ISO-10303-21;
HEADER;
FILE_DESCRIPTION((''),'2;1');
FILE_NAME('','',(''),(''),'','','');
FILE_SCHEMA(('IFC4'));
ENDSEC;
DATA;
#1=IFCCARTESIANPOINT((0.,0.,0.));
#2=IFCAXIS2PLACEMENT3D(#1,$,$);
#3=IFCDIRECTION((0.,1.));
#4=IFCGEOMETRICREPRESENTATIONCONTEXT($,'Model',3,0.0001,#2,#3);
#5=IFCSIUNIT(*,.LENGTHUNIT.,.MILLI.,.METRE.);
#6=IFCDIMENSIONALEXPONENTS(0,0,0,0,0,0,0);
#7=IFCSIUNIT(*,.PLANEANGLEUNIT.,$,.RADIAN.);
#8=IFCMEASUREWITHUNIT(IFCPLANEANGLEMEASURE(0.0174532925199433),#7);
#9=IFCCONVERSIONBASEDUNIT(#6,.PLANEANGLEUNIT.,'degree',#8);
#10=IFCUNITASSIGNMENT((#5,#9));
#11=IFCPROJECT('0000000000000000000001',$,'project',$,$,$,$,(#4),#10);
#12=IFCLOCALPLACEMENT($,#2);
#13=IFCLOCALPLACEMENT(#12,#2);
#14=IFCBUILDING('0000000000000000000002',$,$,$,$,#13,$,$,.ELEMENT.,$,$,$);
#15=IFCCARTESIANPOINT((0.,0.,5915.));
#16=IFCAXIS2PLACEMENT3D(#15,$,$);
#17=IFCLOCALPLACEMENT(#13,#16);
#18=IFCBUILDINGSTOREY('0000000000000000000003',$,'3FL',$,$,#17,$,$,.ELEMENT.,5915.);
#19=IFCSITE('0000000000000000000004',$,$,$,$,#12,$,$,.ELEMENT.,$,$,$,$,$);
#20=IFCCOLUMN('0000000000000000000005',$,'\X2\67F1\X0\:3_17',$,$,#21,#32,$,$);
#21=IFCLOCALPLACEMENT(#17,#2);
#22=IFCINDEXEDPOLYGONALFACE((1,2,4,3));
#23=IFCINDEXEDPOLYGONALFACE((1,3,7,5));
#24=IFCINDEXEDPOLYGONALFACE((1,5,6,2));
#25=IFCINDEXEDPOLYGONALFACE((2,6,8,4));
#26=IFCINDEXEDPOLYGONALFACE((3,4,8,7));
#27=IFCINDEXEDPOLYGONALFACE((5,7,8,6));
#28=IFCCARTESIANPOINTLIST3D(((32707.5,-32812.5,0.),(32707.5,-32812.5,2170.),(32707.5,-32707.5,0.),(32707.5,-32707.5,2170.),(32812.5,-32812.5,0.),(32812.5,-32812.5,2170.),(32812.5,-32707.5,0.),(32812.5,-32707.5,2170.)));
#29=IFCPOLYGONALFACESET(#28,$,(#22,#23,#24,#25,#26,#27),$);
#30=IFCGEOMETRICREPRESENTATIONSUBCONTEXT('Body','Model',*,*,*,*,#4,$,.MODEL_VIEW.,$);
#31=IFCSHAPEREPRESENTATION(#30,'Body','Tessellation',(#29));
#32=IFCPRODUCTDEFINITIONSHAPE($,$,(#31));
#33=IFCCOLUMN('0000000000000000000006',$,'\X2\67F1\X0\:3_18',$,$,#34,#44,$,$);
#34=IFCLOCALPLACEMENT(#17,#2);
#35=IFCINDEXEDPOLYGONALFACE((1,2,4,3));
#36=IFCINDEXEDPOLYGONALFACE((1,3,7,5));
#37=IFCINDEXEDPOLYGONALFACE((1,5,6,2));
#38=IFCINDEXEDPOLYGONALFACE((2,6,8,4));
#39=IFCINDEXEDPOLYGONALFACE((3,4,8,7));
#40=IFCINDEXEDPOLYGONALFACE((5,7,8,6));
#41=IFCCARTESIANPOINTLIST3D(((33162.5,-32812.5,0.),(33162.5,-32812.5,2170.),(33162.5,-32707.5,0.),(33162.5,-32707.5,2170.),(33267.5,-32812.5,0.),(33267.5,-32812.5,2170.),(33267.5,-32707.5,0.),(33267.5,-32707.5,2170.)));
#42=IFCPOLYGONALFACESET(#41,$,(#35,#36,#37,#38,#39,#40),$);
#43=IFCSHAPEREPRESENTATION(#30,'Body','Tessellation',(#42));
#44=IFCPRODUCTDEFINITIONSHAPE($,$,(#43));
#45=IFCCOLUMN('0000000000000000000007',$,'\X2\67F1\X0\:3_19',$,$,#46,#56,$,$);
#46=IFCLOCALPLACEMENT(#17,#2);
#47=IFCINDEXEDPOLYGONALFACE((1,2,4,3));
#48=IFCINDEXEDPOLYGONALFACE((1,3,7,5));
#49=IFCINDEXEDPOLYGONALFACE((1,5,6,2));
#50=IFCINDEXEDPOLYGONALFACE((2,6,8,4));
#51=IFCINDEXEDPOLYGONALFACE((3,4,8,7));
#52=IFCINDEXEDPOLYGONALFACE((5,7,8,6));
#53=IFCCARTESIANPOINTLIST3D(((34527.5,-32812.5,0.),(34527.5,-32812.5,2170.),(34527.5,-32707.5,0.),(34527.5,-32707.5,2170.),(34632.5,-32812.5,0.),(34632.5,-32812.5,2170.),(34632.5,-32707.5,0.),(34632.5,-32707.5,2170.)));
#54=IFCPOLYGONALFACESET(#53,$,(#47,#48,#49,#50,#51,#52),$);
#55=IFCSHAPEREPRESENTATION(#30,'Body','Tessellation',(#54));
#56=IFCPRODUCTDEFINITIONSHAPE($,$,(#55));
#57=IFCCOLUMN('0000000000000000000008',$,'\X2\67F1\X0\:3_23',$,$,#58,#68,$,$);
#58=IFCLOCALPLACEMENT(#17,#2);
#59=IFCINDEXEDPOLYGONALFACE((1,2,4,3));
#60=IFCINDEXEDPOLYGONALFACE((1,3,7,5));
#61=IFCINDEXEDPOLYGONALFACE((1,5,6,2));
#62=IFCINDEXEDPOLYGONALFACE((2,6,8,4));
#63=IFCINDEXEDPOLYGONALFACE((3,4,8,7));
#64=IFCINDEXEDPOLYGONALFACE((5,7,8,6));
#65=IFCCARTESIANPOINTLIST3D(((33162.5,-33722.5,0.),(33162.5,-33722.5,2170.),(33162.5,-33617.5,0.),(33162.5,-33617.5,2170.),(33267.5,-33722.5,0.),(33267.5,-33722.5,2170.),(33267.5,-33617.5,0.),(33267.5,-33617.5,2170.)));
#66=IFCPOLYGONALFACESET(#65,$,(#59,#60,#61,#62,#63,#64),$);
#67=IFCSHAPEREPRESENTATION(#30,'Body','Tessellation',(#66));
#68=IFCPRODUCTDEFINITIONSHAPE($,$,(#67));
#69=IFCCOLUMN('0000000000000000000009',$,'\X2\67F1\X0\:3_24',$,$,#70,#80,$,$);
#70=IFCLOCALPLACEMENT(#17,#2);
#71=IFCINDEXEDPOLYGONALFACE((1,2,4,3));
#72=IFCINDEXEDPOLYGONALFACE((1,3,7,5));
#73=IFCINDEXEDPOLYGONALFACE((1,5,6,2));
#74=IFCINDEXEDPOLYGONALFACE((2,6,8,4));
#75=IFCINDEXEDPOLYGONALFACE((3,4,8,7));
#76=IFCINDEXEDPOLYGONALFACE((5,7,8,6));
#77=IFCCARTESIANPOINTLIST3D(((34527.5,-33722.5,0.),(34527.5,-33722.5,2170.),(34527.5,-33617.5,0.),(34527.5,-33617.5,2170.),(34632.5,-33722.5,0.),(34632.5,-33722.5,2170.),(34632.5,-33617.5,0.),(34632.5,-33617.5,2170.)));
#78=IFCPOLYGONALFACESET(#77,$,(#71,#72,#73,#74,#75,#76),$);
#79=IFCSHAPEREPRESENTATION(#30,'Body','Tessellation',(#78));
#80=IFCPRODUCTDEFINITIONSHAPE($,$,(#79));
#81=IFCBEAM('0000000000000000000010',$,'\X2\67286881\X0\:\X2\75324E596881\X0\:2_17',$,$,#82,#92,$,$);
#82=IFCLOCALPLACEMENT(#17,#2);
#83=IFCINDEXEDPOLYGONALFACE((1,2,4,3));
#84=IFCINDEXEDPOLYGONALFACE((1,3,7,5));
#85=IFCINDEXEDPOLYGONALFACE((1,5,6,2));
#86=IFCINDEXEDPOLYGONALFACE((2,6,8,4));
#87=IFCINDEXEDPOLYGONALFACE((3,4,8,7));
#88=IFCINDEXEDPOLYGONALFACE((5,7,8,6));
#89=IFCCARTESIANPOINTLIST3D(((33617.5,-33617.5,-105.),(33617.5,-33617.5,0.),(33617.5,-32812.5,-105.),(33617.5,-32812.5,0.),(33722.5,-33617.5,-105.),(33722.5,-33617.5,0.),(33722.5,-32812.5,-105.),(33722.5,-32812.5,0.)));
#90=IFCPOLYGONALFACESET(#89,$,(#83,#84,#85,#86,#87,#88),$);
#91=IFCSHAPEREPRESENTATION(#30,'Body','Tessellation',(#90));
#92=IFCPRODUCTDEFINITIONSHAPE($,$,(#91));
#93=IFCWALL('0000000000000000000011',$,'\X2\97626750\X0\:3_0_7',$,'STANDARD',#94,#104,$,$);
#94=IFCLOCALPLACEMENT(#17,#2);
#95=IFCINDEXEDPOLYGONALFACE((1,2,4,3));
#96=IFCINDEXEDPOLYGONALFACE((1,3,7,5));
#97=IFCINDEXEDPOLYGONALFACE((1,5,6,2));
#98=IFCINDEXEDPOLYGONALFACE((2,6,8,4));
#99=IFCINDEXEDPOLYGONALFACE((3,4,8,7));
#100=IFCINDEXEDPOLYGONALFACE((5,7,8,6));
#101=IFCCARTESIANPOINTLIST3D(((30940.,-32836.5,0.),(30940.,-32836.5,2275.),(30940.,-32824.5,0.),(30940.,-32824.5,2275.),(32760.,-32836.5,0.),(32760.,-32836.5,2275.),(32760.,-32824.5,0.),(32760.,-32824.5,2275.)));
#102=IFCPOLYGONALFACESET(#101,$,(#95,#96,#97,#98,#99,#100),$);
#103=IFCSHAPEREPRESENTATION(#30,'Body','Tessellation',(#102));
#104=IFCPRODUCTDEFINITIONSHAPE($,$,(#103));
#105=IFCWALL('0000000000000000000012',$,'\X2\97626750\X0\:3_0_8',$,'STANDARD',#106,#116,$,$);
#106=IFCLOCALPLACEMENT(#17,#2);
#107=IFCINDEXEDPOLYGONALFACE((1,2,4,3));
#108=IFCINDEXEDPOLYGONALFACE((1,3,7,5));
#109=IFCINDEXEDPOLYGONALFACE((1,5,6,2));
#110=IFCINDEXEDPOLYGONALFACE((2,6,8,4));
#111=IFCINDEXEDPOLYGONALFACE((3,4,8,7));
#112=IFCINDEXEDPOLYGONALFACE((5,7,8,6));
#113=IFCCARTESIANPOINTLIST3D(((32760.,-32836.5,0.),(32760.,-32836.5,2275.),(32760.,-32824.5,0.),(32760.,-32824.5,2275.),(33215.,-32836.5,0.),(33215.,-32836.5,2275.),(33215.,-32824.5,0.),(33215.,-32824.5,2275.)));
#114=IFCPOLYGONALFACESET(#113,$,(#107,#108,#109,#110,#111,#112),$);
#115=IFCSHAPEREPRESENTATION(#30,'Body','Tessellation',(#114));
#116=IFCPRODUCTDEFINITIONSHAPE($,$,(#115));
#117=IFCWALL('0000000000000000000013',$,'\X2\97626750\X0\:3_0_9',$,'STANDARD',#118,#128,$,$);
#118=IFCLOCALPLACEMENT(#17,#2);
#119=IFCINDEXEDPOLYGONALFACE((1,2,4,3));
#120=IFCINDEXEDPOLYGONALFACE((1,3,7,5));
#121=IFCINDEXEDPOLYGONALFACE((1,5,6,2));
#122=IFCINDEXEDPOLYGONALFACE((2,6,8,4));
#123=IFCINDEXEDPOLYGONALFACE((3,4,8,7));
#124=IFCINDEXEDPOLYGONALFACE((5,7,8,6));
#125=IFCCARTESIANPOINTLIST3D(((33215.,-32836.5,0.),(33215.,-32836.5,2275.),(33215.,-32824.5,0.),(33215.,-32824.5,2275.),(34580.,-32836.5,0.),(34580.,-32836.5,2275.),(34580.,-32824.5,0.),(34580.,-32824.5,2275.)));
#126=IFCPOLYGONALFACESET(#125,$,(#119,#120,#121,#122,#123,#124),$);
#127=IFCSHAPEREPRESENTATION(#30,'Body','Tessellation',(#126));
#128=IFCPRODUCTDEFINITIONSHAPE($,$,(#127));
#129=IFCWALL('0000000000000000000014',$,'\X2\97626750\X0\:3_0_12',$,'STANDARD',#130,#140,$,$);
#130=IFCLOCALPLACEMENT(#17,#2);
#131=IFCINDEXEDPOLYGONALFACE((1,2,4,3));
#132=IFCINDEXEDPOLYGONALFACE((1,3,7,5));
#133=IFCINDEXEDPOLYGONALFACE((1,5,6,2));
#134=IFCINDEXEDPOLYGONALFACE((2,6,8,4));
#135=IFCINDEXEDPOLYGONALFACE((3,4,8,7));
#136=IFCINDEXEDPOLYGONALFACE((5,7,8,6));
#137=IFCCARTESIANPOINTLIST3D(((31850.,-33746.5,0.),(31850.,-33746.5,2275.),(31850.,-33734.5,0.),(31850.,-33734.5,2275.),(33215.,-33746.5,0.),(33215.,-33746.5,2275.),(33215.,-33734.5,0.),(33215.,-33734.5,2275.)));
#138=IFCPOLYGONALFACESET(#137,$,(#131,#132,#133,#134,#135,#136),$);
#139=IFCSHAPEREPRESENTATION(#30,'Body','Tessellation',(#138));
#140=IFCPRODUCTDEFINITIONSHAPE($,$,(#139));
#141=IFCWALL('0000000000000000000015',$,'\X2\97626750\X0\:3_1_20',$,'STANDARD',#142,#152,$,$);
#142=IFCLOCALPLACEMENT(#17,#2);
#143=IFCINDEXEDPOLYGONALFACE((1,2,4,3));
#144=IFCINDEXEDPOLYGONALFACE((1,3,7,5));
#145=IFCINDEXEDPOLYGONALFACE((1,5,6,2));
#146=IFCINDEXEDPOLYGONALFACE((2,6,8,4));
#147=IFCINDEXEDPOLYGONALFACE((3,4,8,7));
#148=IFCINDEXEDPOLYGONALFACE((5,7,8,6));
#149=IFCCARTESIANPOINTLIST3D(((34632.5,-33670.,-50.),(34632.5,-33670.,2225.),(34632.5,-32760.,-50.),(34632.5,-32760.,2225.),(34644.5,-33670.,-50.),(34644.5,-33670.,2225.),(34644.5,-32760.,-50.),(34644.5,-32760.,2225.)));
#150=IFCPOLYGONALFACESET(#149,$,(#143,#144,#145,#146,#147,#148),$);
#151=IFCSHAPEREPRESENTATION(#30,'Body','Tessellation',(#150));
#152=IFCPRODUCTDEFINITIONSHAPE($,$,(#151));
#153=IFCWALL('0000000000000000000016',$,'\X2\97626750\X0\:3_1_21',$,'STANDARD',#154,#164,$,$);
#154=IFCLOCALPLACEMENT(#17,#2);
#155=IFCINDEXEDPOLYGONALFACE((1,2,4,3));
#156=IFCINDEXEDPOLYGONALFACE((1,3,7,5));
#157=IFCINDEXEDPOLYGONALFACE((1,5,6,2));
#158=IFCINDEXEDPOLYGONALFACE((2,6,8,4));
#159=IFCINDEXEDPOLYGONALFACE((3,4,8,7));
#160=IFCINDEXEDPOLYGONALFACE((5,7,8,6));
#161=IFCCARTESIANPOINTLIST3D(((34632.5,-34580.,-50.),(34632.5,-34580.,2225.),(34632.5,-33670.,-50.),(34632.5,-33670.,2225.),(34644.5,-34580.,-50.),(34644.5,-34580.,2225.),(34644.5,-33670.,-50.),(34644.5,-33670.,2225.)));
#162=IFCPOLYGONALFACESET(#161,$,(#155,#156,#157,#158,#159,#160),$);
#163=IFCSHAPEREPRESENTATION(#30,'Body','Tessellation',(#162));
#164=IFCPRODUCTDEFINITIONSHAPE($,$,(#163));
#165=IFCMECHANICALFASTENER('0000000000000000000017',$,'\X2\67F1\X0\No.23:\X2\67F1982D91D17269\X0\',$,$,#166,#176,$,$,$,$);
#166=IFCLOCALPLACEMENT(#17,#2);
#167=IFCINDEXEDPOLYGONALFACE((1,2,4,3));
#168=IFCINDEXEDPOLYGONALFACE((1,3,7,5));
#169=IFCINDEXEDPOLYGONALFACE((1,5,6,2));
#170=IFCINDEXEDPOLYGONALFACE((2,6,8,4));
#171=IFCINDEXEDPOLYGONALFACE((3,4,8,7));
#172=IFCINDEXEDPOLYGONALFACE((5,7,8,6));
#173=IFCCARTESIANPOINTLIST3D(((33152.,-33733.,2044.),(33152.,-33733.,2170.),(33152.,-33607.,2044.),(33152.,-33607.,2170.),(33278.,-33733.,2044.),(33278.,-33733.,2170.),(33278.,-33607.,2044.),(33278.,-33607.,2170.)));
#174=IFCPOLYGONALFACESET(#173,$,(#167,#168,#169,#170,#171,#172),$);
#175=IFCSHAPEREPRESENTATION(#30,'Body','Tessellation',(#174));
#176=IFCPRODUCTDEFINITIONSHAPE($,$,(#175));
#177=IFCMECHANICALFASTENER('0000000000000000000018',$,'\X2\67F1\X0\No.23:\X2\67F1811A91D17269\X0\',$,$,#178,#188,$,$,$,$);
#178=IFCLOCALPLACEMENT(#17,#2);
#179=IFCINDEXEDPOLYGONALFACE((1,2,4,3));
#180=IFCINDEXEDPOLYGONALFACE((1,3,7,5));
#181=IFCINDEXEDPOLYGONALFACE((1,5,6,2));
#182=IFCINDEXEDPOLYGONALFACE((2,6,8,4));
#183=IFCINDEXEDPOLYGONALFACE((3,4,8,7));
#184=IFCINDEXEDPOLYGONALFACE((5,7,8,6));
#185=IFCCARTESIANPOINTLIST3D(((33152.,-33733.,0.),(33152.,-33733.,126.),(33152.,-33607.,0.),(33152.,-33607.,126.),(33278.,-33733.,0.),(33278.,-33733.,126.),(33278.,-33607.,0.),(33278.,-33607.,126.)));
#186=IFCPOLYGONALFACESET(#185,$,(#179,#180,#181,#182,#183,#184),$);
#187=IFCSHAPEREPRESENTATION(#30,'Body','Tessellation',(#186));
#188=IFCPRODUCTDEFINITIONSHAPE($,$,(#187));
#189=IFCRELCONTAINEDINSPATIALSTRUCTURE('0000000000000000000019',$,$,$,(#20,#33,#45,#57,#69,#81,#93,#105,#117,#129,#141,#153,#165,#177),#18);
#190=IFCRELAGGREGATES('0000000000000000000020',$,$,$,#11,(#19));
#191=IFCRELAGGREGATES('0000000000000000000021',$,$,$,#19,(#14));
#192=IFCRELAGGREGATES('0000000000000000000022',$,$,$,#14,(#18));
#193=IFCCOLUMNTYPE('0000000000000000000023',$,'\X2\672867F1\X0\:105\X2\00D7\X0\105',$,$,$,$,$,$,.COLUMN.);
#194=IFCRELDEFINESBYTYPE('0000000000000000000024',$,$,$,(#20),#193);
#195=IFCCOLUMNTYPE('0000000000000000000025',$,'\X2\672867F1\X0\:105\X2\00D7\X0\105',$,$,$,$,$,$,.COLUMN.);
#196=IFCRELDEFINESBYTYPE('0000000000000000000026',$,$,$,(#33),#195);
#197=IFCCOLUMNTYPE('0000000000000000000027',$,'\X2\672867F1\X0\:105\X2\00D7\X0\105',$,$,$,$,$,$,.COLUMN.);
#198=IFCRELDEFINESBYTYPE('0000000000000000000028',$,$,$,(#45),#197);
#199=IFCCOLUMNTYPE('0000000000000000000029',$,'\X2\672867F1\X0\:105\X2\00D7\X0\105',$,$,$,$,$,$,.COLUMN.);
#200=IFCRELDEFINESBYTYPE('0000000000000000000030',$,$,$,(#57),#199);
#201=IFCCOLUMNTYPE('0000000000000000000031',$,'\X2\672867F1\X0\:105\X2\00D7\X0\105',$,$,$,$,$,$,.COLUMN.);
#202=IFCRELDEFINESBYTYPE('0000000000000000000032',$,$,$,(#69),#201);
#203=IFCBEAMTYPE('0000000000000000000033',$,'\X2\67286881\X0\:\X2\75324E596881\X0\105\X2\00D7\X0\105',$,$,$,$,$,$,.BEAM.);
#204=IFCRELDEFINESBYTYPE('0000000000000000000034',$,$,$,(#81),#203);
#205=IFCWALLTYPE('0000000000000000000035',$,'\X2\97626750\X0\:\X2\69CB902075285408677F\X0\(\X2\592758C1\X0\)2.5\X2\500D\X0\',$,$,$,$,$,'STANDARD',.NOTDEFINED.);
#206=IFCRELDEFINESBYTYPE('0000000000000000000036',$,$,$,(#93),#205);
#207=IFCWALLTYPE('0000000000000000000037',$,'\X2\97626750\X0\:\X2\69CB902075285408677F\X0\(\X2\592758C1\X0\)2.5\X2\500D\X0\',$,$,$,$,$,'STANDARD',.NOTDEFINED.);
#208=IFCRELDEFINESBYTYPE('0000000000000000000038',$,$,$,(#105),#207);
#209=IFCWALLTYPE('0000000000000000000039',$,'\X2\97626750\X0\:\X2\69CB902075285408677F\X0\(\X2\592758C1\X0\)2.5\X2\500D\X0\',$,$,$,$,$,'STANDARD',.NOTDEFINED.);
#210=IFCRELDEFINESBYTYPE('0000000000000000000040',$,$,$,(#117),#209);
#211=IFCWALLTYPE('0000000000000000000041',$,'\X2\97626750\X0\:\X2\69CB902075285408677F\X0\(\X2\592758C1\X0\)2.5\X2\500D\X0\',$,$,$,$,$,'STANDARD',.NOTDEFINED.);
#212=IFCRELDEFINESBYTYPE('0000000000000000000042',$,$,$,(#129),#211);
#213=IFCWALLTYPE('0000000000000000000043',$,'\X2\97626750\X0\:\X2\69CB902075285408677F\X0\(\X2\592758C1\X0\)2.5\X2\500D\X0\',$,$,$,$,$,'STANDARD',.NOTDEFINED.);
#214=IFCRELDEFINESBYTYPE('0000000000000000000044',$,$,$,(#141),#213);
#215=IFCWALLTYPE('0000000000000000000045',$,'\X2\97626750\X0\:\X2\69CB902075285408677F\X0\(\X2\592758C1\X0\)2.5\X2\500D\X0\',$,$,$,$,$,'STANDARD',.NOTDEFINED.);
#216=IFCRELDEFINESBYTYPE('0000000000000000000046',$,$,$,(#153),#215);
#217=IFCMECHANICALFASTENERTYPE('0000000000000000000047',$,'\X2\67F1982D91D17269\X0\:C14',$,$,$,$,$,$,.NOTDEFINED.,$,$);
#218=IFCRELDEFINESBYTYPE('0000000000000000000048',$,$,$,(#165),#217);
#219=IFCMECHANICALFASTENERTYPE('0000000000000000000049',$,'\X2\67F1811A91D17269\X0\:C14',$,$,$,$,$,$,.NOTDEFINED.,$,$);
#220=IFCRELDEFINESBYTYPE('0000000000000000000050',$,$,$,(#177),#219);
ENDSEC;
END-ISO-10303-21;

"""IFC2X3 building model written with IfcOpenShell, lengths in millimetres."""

from ifc_helpers import new_model, entity, si_unit, converted_unit, direction, frame, origin, origin_with_axes, origin_2d, place, context, subcontext, project, spatial, polyline, rectangle, outline, extrude, type_object, element, save


model = new_model("IFC2X3")

# Units and contexts
model_context = context("Model", 3, precision=0.0001, world=origin(), true_north=direction((0.0, 1.0)))
body_context = subcontext(model_context, "Body", "Model", "MODEL_VIEW")
ifc_project = project(units=[si_unit("LENGTHUNIT", "METRE", prefix="MILLI"), converted_unit("PLANEANGLEUNIT", "degree", entity("IfcPlaneAngleMeasure", 0.0174532925199433), si_unit("PLANEANGLEUNIT", "RADIAN"), dimensions=[0, 0, 0, 0, 0, 0, 0])], contexts=[model_context])

# Site, building, storey
site_placement = place(None, origin())
site = spatial("IfcSite", under=ifc_project, at=site_placement, CompositionType="ELEMENT")
building_placement = place(site_placement, origin())
building = spatial("IfcBuilding", under=site, at=building_placement, CompositionType="ELEMENT")
storey_placement = place(building_placement, frame((0.0, 0.0, 5915.0)))
storey = spatial("IfcBuildingStorey", under=building, at=storey_placement, Name="3FL", CompositionType="ELEMENT", Elevation=5915.0)

# Columns
column_type_1 = type_object("IfcColumnType", Name="木柱:105×105", PredefinedType="COLUMN")
column_1_placement = place(storey_placement, frame((32760.0, -32760.0, 0.0)))
element("IfcColumn", 1, at=column_1_placement, inside=storey, type_object=column_type_1, Name="柱:3_17", context=body_context, shape_type="SweptSolid", body=[
    extrude(rectangle(XDim=105.0, YDim=105.0, at=origin_2d()), origin_with_axes(), (0.0, 0.0, 1.0), 2170.0),
])
column_type_2 = type_object("IfcColumnType", Name="木柱:105×105", PredefinedType="COLUMN")
column_2_placement = place(storey_placement, frame((33215.0, -32760.0, 0.0)))
element("IfcColumn", 2, at=column_2_placement, inside=storey, type_object=column_type_2, Name="柱:3_18", context=body_context, shape_type="SweptSolid", body=[
    extrude(rectangle(XDim=105.0, YDim=105.0, at=origin_2d()), origin_with_axes(), (0.0, 0.0, 1.0), 2170.0),
])
column_type_3 = type_object("IfcColumnType", Name="木柱:105×105", PredefinedType="COLUMN")
column_3_placement = place(storey_placement, frame((34580.0, -32760.0, 0.0)))
element("IfcColumn", 3, at=column_3_placement, inside=storey, type_object=column_type_3, Name="柱:3_19", context=body_context, shape_type="SweptSolid", body=[
    extrude(rectangle(XDim=105.0, YDim=105.0, at=origin_2d()), origin_with_axes(), (0.0, 0.0, 1.0), 2170.0),
])
column_type_4 = type_object("IfcColumnType", Name="木柱:105×105", PredefinedType="COLUMN")
column_4_placement = place(storey_placement, frame((33215.0, -33670.0, 0.0)))
element("IfcColumn", 4, at=column_4_placement, inside=storey, type_object=column_type_4, Name="柱:3_23", context=body_context, shape_type="SweptSolid", body=[
    extrude(rectangle(XDim=105.0, YDim=105.0, at=origin_2d()), origin_with_axes(), (0.0, 0.0, 1.0), 2170.0),
])
column_type_5 = type_object("IfcColumnType", Name="木柱:105×105", PredefinedType="COLUMN")
column_5_placement = place(storey_placement, frame((34580.0, -33670.0, 0.0)))
element("IfcColumn", 5, at=column_5_placement, inside=storey, type_object=column_type_5, Name="柱:3_24", context=body_context, shape_type="SweptSolid", body=[
    extrude(rectangle(XDim=105.0, YDim=105.0, at=origin_2d()), origin_with_axes(), (0.0, 0.0, 1.0), 2170.0),
])

# Beam
beam_type = type_object("IfcBeamType", Name="木梁:甲乙梁105×105", PredefinedType="BEAM")
beam_placement = place(storey_placement, frame((33670.0, -32812.5, -52.5), z_axis=(0.0, -1.0, 0.0), x_axis=(1.0, 0.0, 0.0)))
element("IfcBeam", 6, at=beam_placement, inside=storey, type_object=beam_type, Name="木梁:甲乙梁:2_17", context=body_context, shape_type="SweptSolid", body=[
    extrude(rectangle(XDim=105.0, YDim=105.0, at=origin_2d()), origin_with_axes(), (0.0, 0.0, 1.0), 805.0),
])

# Walls
wall_type_1 = type_object("IfcWallType", Name="面材:構造用合板(大壁)2.5倍", ElementType="STANDARD", PredefinedType="NOTDEFINED")
wall_1_placement = place(storey_placement, frame((31850.0, -32824.5, 0.0), z_axis=(0.0, -1.0, 0.0), x_axis=(1.0, 0.0, 0.0)))
element("IfcWall", 7, at=wall_1_placement, inside=storey, type_object=wall_type_1, Name="面材:3_0_7", ObjectType="STANDARD", context=body_context, shape_type="SweptSolid", body=[
    extrude(outline(polyline([(910.0, 0.0, 0.0), (-910.0, 0.0, 0.0), (-910.0, 2275.0, 0.0), (910.0, 2275.0, 0.0), (910.0, 0.0, 0.0)])), origin_with_axes(), (0.0, 0.0, 1.0), 12.0),
])
wall_type_2 = type_object("IfcWallType", Name="面材:構造用合板(大壁)2.5倍", ElementType="STANDARD", PredefinedType="NOTDEFINED")
wall_2_placement = place(storey_placement, frame((32987.5, -32824.5, 0.0), z_axis=(0.0, -1.0, 0.0), x_axis=(1.0, 0.0, 0.0)))
element("IfcWall", 8, at=wall_2_placement, inside=storey, type_object=wall_type_2, Name="面材:3_0_8", ObjectType="STANDARD", context=body_context, shape_type="SweptSolid", body=[
    extrude(outline(polyline([(227.5, 0.0, 0.0), (-227.5, 0.0, 0.0), (-227.5, 2275.0, 0.0), (227.5, 2275.0, 0.0), (227.5, 0.0, 0.0)])), origin_with_axes(), (0.0, 0.0, 1.0), 12.0),
])
wall_type_3 = type_object("IfcWallType", Name="面材:構造用合板(大壁)2.5倍", ElementType="STANDARD", PredefinedType="NOTDEFINED")
wall_3_placement = place(storey_placement, frame((33897.5, -32824.5, 0.0), z_axis=(0.0, -1.0, 0.0), x_axis=(1.0, 0.0, 0.0)))
element("IfcWall", 9, at=wall_3_placement, inside=storey, type_object=wall_type_3, Name="面材:3_0_9", ObjectType="STANDARD", context=body_context, shape_type="SweptSolid", body=[
    extrude(outline(polyline([(682.5, 0.0, 0.0), (-682.5, 0.0, 0.0), (-682.5, 2275.0, 0.0), (682.5, 2275.0, 0.0), (682.5, 0.0, 0.0)])), origin_with_axes(), (0.0, 0.0, 1.0), 12.0),
])
wall_type_4 = type_object("IfcWallType", Name="面材:構造用合板(大壁)2.5倍", ElementType="STANDARD", PredefinedType="NOTDEFINED")
wall_4_placement = place(storey_placement, frame((32532.5, -33734.5, 0.0), z_axis=(0.0, -1.0, 0.0), x_axis=(1.0, 0.0, 0.0)))
element("IfcWall", 10, at=wall_4_placement, inside=storey, type_object=wall_type_4, Name="面材:3_0_12", ObjectType="STANDARD", context=body_context, shape_type="SweptSolid", body=[
    extrude(outline(polyline([(682.5, 0.0, 0.0), (-682.5, 0.0, 0.0), (-682.5, 2275.0, 0.0), (682.5, 2275.0, 0.0), (682.5, 0.0, 0.0)])), origin_with_axes(), (0.0, 0.0, 1.0), 12.0),
])
wall_type_5 = type_object("IfcWallType", Name="面材:構造用合板(大壁)2.5倍", ElementType="STANDARD", PredefinedType="NOTDEFINED")
wall_5_placement = place(storey_placement, frame((34644.5, -33215.0, -50.0), z_axis=(-1.0, 0.0, 0.0), x_axis=(0.0, -1.0, 0.0)))
element("IfcWall", 11, at=wall_5_placement, inside=storey, type_object=wall_type_5, Name="面材:3_1_20", ObjectType="STANDARD", context=body_context, shape_type="SweptSolid", body=[
    extrude(outline(polyline([(455.0, 0.0, 0.0), (-455.0, 0.0, 0.0), (-455.0, 2275.0, 0.0), (455.0, 2275.0, 0.0), (455.0, 0.0, 0.0)])), origin_with_axes(), (0.0, 0.0, 1.0), 12.0),
])
wall_type_6 = type_object("IfcWallType", Name="面材:構造用合板(大壁)2.5倍", ElementType="STANDARD", PredefinedType="NOTDEFINED")
wall_6_placement = place(storey_placement, frame((34644.5, -34125.0, -50.0), z_axis=(-1.0, 0.0, 0.0), x_axis=(0.0, -1.0, 0.0)))
element("IfcWall", 12, at=wall_6_placement, inside=storey, type_object=wall_type_6, Name="面材:3_1_21", ObjectType="STANDARD", context=body_context, shape_type="SweptSolid", body=[
    extrude(outline(polyline([(455.0, 0.0, 0.0), (-455.0, 0.0, 0.0), (-455.0, 2275.0, 0.0), (455.0, 2275.0, 0.0), (455.0, 0.0, 0.0)])), origin_with_axes(), (0.0, 0.0, 1.0), 12.0),
])

# Mechanical fasteners
mechanical_fastener_type_1 = type_object("IfcMechanicalFastenerType", Name="柱頭金物:C14")
mechanical_fastener_1_placement = place(storey_placement, frame((33215.0, -33670.0, 2044.0)))
element("IfcMechanicalFastener", 13, at=mechanical_fastener_1_placement, inside=storey, type_object=mechanical_fastener_type_1, Name="柱No.23:柱頭金物", context=body_context, shape_type="SweptSolid", body=[
    extrude(rectangle(XDim=126.0, YDim=126.0, at=origin_2d()), origin_with_axes(), (0.0, 0.0, 1.0), 126.0),
])
mechanical_fastener_type_2 = type_object("IfcMechanicalFastenerType", Name="柱脚金物:C14")
mechanical_fastener_2_placement = place(storey_placement, frame((33215.0, -33670.0, 0.0)))
element("IfcMechanicalFastener", 14, at=mechanical_fastener_2_placement, inside=storey, type_object=mechanical_fastener_type_2, Name="柱No.23:柱脚金物", context=body_context, shape_type="SweptSolid", body=[
    extrude(rectangle(XDim=126.0, YDim=126.0, at=origin_2d()), origin_with_axes(), (0.0, 0.0, 1.0), 126.0),
])

save(model, "model.ifc")
